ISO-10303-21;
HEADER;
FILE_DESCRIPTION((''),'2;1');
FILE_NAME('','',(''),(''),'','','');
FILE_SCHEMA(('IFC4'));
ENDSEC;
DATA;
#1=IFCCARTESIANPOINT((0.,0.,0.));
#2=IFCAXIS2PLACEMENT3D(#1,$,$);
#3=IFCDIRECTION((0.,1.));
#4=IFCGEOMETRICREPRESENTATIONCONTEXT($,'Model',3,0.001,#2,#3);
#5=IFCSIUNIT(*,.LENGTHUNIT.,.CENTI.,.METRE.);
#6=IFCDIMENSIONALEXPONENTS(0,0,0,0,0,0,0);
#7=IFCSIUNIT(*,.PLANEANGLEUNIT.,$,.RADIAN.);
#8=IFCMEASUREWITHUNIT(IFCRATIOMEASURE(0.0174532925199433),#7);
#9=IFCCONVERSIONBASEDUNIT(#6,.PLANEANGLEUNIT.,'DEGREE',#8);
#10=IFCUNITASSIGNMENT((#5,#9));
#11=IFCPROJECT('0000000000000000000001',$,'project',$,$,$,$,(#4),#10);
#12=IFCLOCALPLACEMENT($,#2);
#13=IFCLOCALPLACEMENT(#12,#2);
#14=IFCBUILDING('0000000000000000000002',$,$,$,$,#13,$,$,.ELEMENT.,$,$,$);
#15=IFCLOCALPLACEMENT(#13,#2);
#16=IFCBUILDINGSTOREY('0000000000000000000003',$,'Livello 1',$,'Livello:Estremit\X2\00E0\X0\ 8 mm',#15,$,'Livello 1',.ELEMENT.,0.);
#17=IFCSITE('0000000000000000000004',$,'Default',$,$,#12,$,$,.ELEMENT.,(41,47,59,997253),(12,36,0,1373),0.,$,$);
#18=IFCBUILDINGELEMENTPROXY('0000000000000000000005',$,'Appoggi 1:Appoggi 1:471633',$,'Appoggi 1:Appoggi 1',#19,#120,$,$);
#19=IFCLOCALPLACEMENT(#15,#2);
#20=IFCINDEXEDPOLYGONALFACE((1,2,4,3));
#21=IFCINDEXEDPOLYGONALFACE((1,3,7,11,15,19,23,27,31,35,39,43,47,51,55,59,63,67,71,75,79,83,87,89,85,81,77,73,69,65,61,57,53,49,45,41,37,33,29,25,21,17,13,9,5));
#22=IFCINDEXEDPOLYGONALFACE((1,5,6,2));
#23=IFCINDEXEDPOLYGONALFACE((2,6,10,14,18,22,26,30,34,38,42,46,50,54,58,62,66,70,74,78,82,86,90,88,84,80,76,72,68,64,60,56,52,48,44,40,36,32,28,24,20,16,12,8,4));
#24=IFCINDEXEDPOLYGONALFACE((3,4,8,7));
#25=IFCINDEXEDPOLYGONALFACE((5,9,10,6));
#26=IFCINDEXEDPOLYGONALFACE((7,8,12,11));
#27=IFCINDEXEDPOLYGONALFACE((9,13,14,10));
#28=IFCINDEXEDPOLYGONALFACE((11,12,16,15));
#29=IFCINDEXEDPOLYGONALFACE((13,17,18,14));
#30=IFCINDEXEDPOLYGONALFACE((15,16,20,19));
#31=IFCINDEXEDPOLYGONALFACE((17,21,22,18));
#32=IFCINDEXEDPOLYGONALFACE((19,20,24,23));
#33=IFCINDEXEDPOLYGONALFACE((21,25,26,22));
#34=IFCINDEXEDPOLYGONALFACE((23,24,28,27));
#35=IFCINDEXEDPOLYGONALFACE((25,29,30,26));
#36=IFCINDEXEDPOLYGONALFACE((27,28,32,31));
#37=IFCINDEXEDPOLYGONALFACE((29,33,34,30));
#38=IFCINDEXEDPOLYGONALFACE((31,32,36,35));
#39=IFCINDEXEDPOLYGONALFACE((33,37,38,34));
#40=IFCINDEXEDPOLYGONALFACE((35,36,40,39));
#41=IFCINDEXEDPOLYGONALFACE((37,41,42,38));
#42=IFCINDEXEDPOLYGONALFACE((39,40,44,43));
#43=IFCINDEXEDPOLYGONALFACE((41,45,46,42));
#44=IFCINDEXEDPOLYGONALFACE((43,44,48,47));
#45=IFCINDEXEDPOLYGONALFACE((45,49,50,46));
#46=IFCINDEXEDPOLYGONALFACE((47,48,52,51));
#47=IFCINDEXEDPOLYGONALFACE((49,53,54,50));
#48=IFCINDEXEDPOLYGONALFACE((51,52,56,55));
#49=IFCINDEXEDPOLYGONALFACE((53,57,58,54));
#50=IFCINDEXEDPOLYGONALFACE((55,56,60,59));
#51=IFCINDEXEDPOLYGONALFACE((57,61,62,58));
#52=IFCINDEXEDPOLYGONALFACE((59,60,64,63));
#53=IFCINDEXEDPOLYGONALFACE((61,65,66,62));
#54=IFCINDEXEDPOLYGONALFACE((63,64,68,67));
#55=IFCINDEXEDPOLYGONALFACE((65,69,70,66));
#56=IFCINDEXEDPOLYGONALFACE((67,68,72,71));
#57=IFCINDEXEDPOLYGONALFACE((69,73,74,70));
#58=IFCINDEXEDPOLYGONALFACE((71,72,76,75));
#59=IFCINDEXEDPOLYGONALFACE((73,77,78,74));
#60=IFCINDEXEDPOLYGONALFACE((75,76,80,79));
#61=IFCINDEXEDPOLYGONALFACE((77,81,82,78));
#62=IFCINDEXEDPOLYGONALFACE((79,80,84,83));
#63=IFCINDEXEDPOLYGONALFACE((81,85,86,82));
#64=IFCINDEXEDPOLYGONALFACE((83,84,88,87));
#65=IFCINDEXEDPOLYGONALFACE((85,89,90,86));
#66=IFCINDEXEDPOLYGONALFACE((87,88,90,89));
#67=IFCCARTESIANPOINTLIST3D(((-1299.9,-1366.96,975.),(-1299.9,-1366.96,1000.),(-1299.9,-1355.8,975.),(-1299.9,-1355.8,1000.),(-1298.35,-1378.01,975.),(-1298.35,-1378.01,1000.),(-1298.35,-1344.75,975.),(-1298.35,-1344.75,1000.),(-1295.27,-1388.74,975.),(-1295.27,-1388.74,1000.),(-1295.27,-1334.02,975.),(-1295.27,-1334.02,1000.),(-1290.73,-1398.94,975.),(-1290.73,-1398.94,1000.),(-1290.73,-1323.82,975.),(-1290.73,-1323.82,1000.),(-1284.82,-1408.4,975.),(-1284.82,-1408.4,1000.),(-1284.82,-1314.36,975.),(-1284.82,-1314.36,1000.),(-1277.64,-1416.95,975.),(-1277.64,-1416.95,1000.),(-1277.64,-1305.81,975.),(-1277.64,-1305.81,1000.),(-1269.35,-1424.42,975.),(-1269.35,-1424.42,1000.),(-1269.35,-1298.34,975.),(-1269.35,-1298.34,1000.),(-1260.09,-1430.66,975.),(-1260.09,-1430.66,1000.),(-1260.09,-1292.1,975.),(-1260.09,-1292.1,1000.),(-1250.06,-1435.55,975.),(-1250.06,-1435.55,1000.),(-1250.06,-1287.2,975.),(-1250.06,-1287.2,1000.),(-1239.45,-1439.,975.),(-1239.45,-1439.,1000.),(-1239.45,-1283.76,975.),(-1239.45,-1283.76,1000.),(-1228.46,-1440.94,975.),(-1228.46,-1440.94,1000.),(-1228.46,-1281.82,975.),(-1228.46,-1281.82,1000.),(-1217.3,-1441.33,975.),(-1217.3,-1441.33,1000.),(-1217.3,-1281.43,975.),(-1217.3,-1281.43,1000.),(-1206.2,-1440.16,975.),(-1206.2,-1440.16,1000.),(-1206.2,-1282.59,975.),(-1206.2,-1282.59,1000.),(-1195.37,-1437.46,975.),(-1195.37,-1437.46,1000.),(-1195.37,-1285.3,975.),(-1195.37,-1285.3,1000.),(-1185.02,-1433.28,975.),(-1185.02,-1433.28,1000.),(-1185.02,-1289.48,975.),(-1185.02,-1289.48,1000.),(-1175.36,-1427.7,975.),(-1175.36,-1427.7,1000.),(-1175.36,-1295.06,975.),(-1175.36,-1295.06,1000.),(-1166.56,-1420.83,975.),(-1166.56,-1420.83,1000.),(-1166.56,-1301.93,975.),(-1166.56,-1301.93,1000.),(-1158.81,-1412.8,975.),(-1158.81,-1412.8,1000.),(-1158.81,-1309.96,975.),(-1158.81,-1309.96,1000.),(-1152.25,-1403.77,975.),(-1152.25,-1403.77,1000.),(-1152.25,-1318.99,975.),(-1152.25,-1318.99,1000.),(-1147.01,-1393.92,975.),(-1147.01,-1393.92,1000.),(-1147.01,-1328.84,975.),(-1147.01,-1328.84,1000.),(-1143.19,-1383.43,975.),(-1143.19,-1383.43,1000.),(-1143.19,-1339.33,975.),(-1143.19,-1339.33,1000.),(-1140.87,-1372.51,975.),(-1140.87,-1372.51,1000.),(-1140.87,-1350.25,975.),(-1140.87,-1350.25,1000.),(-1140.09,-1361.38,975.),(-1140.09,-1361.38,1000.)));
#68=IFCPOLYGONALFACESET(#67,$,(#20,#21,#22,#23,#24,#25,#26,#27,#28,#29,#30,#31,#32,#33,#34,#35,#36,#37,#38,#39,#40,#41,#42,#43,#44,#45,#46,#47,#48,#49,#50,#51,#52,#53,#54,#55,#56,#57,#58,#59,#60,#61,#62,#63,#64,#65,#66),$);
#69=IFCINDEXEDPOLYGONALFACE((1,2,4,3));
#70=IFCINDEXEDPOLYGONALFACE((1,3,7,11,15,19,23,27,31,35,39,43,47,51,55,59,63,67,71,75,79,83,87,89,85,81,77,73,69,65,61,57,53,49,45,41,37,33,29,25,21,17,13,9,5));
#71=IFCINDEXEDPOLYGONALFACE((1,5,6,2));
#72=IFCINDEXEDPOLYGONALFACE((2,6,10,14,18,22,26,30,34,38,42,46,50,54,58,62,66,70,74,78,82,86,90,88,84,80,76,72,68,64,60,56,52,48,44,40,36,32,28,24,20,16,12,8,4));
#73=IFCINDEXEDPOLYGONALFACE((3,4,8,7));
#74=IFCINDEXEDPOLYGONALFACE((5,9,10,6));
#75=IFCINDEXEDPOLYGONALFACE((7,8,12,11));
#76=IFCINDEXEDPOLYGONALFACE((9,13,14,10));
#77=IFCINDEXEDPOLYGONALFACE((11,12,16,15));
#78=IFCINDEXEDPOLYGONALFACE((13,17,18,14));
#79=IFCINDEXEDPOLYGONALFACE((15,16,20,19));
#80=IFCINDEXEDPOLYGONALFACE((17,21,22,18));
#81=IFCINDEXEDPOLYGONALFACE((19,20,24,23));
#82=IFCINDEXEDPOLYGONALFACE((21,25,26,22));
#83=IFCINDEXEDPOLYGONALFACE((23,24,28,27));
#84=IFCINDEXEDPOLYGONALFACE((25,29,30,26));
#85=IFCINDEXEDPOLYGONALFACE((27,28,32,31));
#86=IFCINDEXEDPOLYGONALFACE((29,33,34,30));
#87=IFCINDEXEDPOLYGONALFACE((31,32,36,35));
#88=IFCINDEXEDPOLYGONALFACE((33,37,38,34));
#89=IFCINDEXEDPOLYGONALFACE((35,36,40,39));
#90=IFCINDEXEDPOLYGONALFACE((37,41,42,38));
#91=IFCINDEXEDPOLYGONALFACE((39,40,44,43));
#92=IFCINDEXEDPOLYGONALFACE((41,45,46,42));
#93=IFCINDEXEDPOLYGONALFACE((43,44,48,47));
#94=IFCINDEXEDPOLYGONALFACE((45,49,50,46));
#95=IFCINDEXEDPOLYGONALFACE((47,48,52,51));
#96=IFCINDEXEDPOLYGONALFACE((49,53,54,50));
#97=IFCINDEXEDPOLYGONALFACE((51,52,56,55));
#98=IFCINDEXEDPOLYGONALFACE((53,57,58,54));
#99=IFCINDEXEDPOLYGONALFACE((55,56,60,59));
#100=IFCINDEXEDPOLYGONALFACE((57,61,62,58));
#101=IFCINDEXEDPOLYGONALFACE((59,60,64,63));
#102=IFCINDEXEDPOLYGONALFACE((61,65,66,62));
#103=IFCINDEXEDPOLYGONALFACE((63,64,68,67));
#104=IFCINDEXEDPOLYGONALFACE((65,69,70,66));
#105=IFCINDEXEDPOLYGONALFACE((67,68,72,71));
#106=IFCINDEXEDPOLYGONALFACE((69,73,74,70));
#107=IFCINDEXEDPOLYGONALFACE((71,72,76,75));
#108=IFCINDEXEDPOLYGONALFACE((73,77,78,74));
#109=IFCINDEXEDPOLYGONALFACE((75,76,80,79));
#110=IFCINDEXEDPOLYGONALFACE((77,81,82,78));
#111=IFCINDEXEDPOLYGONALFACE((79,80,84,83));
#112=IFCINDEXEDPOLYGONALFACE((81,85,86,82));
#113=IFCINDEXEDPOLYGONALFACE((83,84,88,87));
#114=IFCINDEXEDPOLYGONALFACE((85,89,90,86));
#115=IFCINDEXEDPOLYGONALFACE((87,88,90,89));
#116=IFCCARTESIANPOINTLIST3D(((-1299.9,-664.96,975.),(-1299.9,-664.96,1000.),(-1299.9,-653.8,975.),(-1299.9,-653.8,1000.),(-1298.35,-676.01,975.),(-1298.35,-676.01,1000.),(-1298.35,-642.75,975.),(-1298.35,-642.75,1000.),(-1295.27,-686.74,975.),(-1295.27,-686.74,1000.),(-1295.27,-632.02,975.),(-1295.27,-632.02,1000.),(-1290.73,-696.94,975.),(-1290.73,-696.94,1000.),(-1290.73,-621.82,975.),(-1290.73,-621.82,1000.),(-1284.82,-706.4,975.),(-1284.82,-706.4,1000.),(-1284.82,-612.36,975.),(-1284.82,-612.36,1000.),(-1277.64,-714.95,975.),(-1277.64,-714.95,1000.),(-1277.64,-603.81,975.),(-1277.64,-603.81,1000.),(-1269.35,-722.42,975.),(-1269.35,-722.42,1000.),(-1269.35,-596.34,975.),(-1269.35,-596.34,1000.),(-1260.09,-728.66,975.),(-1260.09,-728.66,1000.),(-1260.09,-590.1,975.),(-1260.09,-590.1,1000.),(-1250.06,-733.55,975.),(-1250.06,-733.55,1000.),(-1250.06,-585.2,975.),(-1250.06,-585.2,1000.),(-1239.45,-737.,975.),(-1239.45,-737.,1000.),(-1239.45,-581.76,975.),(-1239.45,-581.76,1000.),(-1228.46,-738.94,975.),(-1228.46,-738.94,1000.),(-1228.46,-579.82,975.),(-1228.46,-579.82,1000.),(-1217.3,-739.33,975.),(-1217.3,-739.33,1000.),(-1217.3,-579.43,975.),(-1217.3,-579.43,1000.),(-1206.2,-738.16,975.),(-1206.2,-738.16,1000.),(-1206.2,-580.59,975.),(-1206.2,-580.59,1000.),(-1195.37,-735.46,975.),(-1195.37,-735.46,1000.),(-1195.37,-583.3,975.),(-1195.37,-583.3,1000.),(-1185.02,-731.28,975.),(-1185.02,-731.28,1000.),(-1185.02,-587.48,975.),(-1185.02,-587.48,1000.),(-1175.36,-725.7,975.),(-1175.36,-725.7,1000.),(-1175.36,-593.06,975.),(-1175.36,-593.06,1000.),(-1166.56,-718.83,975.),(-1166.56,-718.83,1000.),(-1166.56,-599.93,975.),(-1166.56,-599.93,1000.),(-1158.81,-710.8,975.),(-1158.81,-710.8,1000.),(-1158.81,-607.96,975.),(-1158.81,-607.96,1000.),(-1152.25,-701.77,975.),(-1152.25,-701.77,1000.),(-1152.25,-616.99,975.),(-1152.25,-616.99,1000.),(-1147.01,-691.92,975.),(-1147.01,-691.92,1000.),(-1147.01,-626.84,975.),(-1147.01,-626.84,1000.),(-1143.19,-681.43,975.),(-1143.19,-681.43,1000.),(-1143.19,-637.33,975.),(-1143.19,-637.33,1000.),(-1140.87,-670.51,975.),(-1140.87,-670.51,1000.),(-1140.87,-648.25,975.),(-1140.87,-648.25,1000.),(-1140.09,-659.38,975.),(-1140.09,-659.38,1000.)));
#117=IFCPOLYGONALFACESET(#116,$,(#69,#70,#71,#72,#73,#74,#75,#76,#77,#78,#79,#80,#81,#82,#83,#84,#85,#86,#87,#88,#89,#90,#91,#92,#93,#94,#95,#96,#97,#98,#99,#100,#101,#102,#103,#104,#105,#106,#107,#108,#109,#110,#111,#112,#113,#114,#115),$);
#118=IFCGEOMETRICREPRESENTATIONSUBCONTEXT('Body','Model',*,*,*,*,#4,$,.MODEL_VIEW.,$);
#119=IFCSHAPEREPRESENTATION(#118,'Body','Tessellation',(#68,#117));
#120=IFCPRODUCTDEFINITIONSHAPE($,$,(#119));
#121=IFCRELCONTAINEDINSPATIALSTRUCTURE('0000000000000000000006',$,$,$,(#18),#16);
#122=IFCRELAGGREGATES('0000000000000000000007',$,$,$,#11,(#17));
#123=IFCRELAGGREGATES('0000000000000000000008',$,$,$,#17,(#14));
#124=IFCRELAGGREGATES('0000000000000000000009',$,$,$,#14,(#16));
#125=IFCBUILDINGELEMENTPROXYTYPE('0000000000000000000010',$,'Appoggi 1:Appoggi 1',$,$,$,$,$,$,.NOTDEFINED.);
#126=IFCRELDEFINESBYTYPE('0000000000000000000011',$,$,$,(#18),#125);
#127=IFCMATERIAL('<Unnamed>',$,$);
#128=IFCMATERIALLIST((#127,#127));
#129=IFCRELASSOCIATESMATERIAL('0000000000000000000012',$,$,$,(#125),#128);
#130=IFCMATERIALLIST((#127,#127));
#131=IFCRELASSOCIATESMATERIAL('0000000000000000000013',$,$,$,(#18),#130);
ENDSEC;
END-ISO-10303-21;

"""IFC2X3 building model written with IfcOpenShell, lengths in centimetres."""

from ifc_helpers import new_model, entity, si_unit, converted_unit, direction, frame, frame_2d, origin, place, context, subcontext, project, spatial, circle, extrude, source, transform, mapped, material, material_list, type_object, type_shapes, element, save


model = new_model("IFC2X3")

# Units and contexts
model_context = context("Model", 3, precision=0.001, world=origin(), true_north=direction((0.0, 1.0)))
body_context = subcontext(model_context, "Body", "Model", "MODEL_VIEW")
ifc_project = project(units=[si_unit("LENGTHUNIT", "METRE", prefix="CENTI"), converted_unit("PLANEANGLEUNIT", "DEGREE", entity("IfcRatioMeasure", 0.0174532925199433), si_unit("PLANEANGLEUNIT", "RADIAN"), dimensions=[0, 0, 0, 0, 0, 0, 0])], contexts=[model_context])

# Site, building, storey
site_placement = place(None, origin())
site = spatial("IfcSite", under=ifc_project, at=site_placement, Name="Default", CompositionType="ELEMENT", RefLatitude=(41, 47, 59, 997253), RefLongitude=(12, 36, 0, 1373), RefElevation=0.0)
building_placement = place(site_placement, origin())
building = spatial("IfcBuilding", under=site, at=building_placement, CompositionType="ELEMENT")
storey_placement = place(building_placement, origin())
storey = spatial("IfcBuildingStorey", under=building, at=storey_placement, Name="Livello 1", ObjectType="Livello:Estremità 8 mm", LongName="Livello 1", CompositionType="ELEMENT", Elevation=0.0)

# Shared definitions
ifc_material = material(Name="<Unnamed>")

# Building element proxy
ifc_material_list_1 = material_list([ifc_material, ifc_material])
ifc_material_list_2 = material_list([ifc_material, ifc_material])
building_element_proxy_type_1 = type_object("IfcBuildingElementProxyType", Name="Appoggi 1:Appoggi 1", PredefinedType="NOTDEFINED", material=ifc_material_list_2)
shared_shape_1 = source(origin(), body_context, "Body", "SweptSolid", [
    extrude(circle(Radius=80.0, at=frame_2d((0.0, 0.0), x_axis=(1.0, 0.0))), frame((-1220.09, -1361.38, 975.0)), (0.0, 0.0, 1.0), 25.0),
    extrude(circle(Radius=80.0, at=frame_2d((0.0, 0.0), x_axis=(1.0, 0.0))), frame((-1220.09, -659.38, 975.0)), (0.0, 0.0, 1.0), 25.0),
])
type_shapes(building_element_proxy_type_1, [shared_shape_1])
proxy_1_placement = place(storey_placement, origin())
element("IfcBuildingElementProxy", 1, at=proxy_1_placement, inside=storey, type_object=building_element_proxy_type_1, material=ifc_material_list_1, Name="Appoggi 1:Appoggi 1:471633", ObjectType="Appoggi 1:Appoggi 1", context=body_context, shape_type="MappedRepresentation", body=[
    mapped(shared_shape_1, transform((0.0, 0.0, 0.0), scale=1.0)),
])

save(model, "model.ifc")
